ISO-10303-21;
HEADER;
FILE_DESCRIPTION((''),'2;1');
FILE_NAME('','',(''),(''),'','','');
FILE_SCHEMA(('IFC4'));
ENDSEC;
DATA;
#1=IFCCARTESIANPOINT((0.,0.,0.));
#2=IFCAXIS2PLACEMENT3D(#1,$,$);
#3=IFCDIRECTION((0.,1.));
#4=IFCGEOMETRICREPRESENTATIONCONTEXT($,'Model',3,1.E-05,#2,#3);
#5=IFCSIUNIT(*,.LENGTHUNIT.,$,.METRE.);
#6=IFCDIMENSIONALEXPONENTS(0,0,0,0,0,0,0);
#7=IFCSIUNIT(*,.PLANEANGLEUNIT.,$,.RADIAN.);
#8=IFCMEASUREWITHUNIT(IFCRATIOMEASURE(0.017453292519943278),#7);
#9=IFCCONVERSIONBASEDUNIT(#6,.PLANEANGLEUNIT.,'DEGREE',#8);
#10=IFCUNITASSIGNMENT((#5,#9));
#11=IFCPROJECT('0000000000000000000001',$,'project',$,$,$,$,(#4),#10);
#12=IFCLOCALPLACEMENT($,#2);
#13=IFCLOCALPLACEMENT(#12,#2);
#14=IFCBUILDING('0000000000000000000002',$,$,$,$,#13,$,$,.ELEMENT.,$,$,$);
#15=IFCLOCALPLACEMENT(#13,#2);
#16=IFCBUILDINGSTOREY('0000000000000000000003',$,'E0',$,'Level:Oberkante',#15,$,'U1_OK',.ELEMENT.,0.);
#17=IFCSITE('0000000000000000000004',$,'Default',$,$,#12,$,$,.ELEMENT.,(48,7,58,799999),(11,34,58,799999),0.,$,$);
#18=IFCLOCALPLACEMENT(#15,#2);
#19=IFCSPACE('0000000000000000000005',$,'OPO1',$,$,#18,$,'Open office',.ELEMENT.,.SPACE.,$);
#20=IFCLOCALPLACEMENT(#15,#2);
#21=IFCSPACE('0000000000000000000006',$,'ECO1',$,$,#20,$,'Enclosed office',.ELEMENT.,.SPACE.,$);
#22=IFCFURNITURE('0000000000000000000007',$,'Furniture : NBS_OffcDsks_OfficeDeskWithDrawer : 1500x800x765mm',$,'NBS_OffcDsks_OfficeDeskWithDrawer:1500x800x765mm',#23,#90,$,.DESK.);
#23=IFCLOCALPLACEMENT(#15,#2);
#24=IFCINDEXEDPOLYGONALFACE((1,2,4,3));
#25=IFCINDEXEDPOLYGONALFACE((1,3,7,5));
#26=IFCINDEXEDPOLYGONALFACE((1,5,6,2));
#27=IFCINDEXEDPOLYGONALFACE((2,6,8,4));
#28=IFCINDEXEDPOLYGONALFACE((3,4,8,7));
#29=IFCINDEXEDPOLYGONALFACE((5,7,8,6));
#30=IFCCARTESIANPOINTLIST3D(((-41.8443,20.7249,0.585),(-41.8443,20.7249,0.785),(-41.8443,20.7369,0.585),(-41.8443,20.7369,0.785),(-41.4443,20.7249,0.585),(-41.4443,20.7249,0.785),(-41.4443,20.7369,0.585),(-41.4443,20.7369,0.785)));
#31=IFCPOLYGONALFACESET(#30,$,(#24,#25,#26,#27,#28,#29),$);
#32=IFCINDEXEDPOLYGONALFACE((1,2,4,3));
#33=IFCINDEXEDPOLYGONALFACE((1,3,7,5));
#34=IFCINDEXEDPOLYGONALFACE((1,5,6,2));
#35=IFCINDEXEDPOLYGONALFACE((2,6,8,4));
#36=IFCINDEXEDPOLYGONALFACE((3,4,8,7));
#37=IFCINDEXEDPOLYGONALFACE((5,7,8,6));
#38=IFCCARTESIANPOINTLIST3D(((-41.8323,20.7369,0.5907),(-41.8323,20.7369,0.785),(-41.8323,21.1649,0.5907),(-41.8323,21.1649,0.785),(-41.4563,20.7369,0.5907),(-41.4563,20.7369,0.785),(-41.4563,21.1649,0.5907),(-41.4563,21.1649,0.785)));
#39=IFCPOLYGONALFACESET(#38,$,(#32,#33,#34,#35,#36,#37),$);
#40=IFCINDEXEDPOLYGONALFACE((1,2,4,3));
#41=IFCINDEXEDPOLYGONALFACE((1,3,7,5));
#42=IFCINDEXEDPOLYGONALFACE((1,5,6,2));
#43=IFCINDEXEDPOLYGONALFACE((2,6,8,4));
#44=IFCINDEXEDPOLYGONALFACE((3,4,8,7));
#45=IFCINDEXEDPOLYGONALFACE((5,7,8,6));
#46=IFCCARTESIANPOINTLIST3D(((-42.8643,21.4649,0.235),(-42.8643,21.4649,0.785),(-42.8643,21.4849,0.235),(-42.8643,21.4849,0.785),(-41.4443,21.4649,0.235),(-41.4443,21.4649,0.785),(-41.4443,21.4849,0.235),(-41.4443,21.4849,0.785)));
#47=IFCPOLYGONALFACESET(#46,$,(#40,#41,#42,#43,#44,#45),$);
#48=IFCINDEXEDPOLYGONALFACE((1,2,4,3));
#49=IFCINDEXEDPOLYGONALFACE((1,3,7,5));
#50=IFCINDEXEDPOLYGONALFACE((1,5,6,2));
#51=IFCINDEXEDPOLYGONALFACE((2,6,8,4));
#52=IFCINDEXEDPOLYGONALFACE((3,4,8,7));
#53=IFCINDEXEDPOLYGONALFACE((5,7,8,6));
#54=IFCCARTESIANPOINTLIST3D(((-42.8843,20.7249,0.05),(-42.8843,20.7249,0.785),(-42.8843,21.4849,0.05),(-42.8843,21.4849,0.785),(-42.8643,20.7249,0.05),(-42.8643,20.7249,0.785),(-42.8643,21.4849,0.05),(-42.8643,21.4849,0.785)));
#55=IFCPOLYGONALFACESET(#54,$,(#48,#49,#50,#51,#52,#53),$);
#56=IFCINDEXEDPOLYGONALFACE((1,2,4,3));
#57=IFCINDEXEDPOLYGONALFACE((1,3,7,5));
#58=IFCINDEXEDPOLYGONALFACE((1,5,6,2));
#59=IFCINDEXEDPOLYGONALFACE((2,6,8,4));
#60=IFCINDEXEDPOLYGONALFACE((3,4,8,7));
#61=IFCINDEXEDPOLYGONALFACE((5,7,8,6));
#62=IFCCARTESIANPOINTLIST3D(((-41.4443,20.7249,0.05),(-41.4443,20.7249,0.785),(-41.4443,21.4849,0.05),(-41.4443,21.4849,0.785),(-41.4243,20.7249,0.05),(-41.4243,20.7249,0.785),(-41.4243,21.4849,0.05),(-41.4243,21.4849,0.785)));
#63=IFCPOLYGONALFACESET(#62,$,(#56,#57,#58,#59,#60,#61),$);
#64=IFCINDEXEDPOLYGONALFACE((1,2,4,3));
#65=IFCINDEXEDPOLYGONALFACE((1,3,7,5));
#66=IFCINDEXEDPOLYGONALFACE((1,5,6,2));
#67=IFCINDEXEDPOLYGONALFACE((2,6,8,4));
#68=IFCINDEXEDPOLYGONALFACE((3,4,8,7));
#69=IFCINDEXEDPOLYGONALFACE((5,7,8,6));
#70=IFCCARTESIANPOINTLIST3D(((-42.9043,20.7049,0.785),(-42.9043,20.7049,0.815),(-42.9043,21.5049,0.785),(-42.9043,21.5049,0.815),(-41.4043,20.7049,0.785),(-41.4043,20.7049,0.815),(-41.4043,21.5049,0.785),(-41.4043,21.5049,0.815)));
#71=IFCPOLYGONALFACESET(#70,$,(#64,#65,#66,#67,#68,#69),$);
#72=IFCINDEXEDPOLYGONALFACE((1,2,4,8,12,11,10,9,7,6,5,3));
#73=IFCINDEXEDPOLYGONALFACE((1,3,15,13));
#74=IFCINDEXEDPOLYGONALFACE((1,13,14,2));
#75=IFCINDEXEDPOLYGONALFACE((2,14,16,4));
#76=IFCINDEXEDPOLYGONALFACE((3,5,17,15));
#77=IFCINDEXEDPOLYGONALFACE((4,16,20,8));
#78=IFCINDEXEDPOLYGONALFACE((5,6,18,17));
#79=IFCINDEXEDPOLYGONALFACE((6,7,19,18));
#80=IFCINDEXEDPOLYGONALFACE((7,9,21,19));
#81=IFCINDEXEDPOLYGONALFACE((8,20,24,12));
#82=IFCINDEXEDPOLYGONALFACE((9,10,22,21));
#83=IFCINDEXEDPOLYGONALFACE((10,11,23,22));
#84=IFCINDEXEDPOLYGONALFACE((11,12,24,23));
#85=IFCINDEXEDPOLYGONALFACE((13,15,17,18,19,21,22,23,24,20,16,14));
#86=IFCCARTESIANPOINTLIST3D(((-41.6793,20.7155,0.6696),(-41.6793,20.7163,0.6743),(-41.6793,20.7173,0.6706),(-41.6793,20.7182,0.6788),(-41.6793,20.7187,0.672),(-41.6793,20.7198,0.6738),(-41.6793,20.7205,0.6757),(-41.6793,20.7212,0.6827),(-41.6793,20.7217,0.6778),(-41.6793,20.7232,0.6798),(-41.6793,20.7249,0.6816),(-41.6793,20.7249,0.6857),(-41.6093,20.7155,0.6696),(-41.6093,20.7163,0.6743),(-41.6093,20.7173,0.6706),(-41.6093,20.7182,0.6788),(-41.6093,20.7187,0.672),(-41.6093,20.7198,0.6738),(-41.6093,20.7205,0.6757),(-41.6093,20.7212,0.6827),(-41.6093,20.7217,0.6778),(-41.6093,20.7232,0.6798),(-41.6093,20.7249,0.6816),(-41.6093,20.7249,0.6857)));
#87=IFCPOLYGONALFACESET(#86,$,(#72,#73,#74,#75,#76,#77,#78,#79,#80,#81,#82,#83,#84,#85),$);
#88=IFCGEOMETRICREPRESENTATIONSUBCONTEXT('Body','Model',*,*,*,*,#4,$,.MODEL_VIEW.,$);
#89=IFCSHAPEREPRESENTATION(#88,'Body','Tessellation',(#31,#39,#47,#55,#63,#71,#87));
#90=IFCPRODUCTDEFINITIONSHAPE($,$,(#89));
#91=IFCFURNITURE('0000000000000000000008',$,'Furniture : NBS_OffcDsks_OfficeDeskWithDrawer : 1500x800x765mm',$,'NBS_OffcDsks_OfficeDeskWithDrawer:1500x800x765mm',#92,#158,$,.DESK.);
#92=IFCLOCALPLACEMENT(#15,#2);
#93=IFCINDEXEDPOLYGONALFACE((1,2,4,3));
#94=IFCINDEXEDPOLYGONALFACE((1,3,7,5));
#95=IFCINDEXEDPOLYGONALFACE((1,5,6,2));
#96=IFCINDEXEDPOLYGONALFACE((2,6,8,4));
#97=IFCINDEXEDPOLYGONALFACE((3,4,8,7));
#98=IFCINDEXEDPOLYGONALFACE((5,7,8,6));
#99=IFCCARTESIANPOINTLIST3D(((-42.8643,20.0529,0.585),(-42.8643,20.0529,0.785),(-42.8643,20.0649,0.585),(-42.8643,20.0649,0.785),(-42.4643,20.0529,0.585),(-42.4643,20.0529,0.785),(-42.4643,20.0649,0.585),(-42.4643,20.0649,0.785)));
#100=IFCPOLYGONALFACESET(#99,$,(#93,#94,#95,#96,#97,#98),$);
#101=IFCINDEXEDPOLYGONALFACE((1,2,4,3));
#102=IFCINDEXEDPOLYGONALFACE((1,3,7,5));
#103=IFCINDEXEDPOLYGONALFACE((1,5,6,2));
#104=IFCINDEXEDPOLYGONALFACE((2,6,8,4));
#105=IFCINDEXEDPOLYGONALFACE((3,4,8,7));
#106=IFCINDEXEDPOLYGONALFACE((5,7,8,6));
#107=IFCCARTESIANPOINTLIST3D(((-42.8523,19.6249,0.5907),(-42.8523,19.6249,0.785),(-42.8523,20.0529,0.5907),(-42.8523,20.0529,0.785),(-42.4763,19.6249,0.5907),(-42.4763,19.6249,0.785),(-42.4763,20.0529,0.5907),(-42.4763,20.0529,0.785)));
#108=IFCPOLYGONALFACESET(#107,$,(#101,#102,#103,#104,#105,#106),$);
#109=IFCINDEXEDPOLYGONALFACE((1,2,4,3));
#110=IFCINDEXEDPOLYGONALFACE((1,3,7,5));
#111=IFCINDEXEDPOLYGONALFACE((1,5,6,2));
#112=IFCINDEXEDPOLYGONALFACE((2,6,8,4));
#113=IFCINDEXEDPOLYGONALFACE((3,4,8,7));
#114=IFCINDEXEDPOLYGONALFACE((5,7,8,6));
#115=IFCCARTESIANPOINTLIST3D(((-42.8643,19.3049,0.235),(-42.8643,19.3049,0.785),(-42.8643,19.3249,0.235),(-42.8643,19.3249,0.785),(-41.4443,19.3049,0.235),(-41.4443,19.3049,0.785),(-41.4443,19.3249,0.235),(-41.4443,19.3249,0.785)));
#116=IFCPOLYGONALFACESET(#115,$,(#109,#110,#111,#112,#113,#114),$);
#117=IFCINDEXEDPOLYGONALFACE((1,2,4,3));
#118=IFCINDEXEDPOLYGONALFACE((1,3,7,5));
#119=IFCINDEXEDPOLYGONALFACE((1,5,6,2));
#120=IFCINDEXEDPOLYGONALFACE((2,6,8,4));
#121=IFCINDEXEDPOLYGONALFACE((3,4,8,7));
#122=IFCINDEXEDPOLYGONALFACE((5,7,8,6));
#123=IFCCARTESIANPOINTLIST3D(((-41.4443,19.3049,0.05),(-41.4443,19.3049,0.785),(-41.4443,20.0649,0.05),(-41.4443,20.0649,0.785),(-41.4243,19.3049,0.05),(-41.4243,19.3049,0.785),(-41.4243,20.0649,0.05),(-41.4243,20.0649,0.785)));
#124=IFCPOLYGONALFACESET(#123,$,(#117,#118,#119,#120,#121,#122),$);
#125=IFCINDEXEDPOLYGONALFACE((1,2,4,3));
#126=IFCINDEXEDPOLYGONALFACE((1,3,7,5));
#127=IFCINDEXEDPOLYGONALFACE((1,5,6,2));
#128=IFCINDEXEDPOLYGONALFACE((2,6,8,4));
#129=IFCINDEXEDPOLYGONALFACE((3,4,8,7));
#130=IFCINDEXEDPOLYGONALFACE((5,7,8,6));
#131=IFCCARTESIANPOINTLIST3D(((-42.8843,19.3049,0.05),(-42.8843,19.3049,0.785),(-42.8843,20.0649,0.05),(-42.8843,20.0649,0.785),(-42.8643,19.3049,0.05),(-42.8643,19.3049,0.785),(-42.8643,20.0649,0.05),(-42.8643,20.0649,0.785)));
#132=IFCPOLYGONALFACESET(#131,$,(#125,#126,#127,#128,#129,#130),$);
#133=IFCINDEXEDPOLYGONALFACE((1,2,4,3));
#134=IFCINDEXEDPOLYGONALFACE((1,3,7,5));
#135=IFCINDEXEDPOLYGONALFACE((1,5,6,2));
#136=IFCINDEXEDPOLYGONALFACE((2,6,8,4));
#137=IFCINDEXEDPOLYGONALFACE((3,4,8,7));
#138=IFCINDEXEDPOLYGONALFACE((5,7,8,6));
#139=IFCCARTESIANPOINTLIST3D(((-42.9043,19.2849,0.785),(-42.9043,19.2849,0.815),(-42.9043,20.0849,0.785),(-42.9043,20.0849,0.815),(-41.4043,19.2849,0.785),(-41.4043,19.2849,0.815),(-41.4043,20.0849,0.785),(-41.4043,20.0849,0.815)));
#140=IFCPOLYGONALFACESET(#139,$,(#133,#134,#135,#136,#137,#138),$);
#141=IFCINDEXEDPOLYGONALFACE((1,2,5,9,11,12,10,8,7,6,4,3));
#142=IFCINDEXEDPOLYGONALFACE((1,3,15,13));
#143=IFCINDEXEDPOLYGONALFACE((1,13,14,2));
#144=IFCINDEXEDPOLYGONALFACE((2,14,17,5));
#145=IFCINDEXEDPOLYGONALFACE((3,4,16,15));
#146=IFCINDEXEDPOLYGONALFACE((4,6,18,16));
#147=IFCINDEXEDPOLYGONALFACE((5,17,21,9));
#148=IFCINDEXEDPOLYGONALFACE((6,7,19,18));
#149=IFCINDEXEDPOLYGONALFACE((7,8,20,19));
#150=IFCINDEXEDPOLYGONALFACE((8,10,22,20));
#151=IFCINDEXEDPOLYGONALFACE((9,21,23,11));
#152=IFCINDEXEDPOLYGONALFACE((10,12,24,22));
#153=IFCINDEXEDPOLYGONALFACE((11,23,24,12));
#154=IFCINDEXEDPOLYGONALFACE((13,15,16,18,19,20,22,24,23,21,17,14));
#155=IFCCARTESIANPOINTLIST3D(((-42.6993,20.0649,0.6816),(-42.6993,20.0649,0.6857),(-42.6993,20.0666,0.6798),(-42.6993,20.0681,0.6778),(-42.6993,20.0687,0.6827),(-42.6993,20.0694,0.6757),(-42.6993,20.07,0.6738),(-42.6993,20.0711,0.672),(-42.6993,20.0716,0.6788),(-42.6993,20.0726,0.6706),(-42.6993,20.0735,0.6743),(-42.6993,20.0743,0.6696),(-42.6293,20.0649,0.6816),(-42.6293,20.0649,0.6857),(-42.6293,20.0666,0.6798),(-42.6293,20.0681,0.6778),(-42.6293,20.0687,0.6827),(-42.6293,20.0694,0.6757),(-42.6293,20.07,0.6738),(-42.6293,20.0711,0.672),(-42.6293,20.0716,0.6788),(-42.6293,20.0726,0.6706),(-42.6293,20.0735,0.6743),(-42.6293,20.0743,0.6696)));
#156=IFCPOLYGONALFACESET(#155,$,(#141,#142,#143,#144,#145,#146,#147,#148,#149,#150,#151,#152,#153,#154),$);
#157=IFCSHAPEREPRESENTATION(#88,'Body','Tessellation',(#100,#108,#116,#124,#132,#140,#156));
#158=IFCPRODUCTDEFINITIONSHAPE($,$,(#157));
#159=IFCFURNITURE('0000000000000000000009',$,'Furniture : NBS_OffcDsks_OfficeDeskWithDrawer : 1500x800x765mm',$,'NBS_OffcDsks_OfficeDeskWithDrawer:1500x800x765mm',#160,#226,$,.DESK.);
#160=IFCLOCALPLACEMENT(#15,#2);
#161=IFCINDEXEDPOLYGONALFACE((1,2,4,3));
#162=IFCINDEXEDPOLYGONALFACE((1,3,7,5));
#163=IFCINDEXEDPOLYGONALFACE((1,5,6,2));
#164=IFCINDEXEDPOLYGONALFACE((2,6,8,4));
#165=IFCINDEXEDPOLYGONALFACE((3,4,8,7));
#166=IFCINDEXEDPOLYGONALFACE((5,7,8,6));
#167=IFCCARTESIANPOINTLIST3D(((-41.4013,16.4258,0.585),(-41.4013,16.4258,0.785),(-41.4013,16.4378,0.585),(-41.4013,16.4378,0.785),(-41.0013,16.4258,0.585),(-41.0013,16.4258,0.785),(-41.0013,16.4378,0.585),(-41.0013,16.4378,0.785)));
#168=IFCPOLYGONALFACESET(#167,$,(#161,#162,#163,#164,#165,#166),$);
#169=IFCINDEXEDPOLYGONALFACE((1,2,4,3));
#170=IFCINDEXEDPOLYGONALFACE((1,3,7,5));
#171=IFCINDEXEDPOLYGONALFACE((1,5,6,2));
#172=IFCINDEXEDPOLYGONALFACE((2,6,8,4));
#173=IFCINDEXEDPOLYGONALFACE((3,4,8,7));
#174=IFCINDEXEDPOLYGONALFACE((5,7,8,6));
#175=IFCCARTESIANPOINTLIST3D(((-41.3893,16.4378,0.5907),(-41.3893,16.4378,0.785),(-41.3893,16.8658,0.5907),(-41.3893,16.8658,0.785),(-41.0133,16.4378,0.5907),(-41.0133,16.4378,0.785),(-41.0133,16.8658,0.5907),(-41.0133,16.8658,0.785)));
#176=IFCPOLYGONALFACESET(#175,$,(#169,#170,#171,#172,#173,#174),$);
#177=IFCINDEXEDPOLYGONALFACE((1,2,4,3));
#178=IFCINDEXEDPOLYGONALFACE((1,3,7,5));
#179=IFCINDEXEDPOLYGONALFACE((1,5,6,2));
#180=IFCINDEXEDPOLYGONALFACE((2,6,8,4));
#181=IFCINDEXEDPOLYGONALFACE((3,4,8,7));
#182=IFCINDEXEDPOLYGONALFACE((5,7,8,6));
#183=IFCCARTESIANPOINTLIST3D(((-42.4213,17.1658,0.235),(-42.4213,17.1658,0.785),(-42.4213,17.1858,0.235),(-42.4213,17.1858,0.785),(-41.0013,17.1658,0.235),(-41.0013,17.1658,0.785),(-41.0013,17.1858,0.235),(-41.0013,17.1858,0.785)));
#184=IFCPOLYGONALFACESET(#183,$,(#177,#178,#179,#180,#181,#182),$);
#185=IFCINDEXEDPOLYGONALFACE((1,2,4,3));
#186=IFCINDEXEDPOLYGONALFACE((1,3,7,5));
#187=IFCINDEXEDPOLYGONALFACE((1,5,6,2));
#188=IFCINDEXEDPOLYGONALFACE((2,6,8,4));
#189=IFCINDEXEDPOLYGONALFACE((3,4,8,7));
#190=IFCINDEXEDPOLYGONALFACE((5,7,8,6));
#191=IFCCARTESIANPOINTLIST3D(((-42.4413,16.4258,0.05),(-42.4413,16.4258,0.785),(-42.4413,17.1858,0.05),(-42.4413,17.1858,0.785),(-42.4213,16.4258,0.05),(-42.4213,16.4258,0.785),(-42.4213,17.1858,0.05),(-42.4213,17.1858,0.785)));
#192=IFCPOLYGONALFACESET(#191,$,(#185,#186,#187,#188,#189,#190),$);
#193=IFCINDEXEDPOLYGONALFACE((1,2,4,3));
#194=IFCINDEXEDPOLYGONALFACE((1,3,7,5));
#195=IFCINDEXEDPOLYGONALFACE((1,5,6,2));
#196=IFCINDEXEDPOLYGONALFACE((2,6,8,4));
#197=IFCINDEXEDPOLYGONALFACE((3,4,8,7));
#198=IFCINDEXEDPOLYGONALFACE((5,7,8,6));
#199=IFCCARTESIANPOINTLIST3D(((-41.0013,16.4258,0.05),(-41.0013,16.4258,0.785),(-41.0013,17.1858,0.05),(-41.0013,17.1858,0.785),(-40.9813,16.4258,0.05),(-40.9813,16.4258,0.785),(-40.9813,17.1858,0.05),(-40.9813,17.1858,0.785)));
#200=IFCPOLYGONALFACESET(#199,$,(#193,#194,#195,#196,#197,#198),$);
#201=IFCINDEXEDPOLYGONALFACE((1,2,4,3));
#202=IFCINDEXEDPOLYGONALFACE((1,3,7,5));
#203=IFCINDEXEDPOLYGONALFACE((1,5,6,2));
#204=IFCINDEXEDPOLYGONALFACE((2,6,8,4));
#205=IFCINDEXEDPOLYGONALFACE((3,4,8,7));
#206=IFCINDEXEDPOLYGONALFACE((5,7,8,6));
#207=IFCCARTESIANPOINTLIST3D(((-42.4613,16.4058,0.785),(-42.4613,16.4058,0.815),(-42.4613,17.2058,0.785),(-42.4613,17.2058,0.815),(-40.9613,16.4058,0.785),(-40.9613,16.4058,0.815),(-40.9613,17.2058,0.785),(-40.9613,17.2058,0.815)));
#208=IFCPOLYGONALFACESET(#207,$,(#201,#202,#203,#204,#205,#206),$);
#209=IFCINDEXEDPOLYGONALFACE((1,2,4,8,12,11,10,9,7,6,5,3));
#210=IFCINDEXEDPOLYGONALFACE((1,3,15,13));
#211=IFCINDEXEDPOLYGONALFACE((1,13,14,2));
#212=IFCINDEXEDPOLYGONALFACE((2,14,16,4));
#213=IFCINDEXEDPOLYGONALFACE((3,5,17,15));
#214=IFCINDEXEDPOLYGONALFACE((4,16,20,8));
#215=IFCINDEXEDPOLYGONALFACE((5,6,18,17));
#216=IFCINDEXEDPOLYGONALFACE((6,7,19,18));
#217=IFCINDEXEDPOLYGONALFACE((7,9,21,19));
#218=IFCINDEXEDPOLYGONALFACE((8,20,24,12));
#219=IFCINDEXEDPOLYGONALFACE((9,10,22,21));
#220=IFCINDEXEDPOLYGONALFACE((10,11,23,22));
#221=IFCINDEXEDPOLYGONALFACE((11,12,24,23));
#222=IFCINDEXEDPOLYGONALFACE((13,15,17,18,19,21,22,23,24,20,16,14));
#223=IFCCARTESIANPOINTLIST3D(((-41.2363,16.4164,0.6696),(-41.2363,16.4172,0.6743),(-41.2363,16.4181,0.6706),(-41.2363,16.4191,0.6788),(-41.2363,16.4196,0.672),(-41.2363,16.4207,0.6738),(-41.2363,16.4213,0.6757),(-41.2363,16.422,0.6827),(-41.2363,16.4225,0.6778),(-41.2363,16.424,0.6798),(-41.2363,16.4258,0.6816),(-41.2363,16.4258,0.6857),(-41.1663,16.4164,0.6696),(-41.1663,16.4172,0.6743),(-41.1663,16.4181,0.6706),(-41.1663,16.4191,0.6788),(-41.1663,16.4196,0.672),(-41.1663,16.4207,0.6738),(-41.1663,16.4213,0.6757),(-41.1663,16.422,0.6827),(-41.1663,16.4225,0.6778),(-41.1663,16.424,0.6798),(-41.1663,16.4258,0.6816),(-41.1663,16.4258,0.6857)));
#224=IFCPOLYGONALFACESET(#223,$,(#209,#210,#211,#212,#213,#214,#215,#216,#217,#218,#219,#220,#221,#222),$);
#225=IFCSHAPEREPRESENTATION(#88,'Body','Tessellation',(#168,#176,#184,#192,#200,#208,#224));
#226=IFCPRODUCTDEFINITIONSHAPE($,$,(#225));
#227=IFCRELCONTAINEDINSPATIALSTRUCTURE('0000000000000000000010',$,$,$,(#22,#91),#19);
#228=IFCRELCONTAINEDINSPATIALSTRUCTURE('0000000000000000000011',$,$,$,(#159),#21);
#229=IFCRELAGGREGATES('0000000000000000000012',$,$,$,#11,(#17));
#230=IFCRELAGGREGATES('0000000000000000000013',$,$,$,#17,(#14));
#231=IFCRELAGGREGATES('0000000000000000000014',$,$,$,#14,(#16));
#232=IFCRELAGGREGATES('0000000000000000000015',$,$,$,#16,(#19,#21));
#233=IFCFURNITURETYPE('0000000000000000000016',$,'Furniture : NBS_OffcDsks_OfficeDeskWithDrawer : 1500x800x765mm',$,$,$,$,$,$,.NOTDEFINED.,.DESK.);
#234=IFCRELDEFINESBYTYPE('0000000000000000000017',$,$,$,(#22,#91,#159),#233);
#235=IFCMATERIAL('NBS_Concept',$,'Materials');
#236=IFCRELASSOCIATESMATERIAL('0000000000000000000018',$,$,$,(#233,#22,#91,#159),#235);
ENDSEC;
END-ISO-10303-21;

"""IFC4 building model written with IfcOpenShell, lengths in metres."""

from ifc_helpers import new_model, entity, si_unit, converted_unit, direction, frame, origin, place, context, subcontext, project, spatial, line, arc, indexed_curve, outline, extrude, source, transform, mapped, material, type_object, type_shapes, element, save


model = new_model("IFC4")

# Units and contexts
model_context = context("Model", 3, precision=1e-05, world=origin(), true_north=direction((0.0, 1.0)))
body_context = subcontext(model_context, "Body", "Model", "MODEL_VIEW")
ifc_project = project(units=[si_unit("LENGTHUNIT", "METRE"), converted_unit("PLANEANGLEUNIT", "DEGREE", entity("IfcRatioMeasure", 0.017453292519943278), si_unit("PLANEANGLEUNIT", "RADIAN"), dimensions=[0, 0, 0, 0, 0, 0, 0])], contexts=[model_context])

# Site, building, storey
site_placement = place(None, origin())
site = spatial("IfcSite", under=ifc_project, at=site_placement, Name="Default", CompositionType="ELEMENT", RefLatitude=(48, 7, 58, 799999), RefLongitude=(11, 34, 58, 799999), RefElevation=0.0)
building_placement = place(site_placement, origin())
building = spatial("IfcBuilding", under=site, at=building_placement, CompositionType="ELEMENT")
storey_placement = place(building_placement, origin())
storey = spatial("IfcBuildingStorey", under=building, at=storey_placement, Name="E0", ObjectType="Level:Oberkante", LongName="U1_OK", CompositionType="ELEMENT", Elevation=0.0)

# Shared definitions
space_1_placement = place(storey_placement, origin())
space_1 = spatial("IfcSpace", under=storey, at=space_1_placement, Name="OPO1", LongName="Open office", CompositionType="ELEMENT", PredefinedType="SPACE")

# Furniture
ifc_material_1 = material(Name="NBS_Concept", Category="Materials")
furniture_type_1 = type_object("IfcFurnitureType", Name="Furniture : NBS_OffcDsks_OfficeDeskWithDrawer : 1500x800x765mm", AssemblyPlace="NOTDEFINED", PredefinedType="DESK", material=ifc_material_1)
shared_shape_1 = source(origin(), body_context, "Body", "SweptSolid", [
    extrude(outline(indexed_curve([(-0.006, -0.2), (0.006, -0.2), (0.006, 0.2), (-0.006, 0.2), (-0.006, -0.2)], self_intersect=False)), frame((0.51, -0.374, 0.535), z_axis=(0.0, 0.0, 1.0), x_axis=(0.0, 1.0, 0.0)), (0.0, 0.0, 1.0), 0.2),
    extrude(outline(indexed_curve([(-0.188, -0.214), (0.188, -0.214), (0.188, 0.214), (-0.188, 0.214), (-0.188, -0.214)], self_intersect=False)), frame((0.51, -0.154, 0.5407), z_axis=(0.0, 0.0, 1.0), x_axis=(-1.0, 0.0, 0.0)), (0.0, 0.0, 1.0), 0.1943),
    extrude(outline(indexed_curve([(-0.71, -0.01), (0.71, -0.01), (0.71, 0.01), (-0.71, 0.01), (-0.71, -0.01)], self_intersect=False)), frame((0.0, 0.37, 0.185), z_axis=(0.0, 0.0, 1.0), x_axis=(-1.0, 0.0, 0.0)), (0.0, 0.0, 1.0), 0.55),
    extrude(outline(indexed_curve([(-0.01, -0.38), (0.01, -0.38), (0.01, 0.38), (-0.01, 0.38), (-0.01, -0.38)], self_intersect=False)), frame((-0.72, 0.0, 0.0), z_axis=(0.0, 0.0, 1.0), x_axis=(-1.0, 0.0, 0.0)), (0.0, 0.0, 1.0), 0.735),
    extrude(outline(indexed_curve([(-0.01, -0.38), (0.01, -0.38), (0.01, 0.38), (-0.01, 0.38), (-0.01, -0.38)], self_intersect=False)), frame((0.72, 0.0, 0.0), z_axis=(0.0, 0.0, 1.0), x_axis=(-1.0, 0.0, 0.0)), (0.0, 0.0, 1.0), 0.735),
    extrude(outline(indexed_curve([(-0.75, -0.4), (0.75, -0.4), (0.75, 0.4), (-0.75, 0.4), (-0.75, -0.4)], self_intersect=False)), frame((0.0, 0.0, 0.735), z_axis=(0.0, 0.0, 1.0), x_axis=(-1.0, 0.0, 0.0)), (0.0, 0.0, 1.0), 0.03),
    extrude(outline(indexed_curve([(0.0086, -0.0059), (0.0061, -0.0027), (0.0025, -0.001), (-0.0007, 0.0009), (-0.0034, 0.0035), (-0.0076, 0.0035), (-0.0007, -0.0032)], segments=[arc(1, 2, 3), arc(3, 4, 5), line(5, 6), arc(6, 7, 1)], self_intersect=False)), frame((0.475, -0.3835, 0.6281), z_axis=(1.0, 0.0, 0.0), x_axis=(0.0, 0.0, -1.0)), (0.0, 0.0, 1.0), 0.07),
])
type_shapes(furniture_type_1, [shared_shape_1])
furniture_1_placement = place(space_1_placement, frame((-42.1543, 21.1049, 0.05)))
element("IfcFurniture", 1, at=furniture_1_placement, inside=space_1, type_object=furniture_type_1, material=ifc_material_1, Name="Furniture : NBS_OffcDsks_OfficeDeskWithDrawer : 1500x800x765mm", ObjectType="NBS_OffcDsks_OfficeDeskWithDrawer:1500x800x765mm", PredefinedType="DESK", context=body_context, shape_type="MappedRepresentation", body=[
    mapped(shared_shape_1, transform((0.0, 0.0, 0.0), scale=1.0)),
])
furniture_2_placement = place(space_1_placement, frame((-42.1543, 19.6849, 0.05), z_axis=(0.0, 0.0, 1.0), x_axis=(-1.0, 0.0, 0.0)))
element("IfcFurniture", 2, at=furniture_2_placement, inside=space_1, type_object=furniture_type_1, material=ifc_material_1, Name="Furniture : NBS_OffcDsks_OfficeDeskWithDrawer : 1500x800x765mm", ObjectType="NBS_OffcDsks_OfficeDeskWithDrawer:1500x800x765mm", PredefinedType="DESK", context=body_context, shape_type="MappedRepresentation", body=[
    mapped(shared_shape_1, transform((0.0, 0.0, 0.0), scale=1.0)),
])

# Shared definitions
space_2_placement = place(storey_placement, origin())
space_2 = spatial("IfcSpace", under=storey, at=space_2_placement, Name="ECO1", LongName="Enclosed office", CompositionType="ELEMENT", PredefinedType="SPACE")

# Furniture
furniture_3_placement = place(space_2_placement, frame((-41.7113, 16.8058, 0.05)))
element("IfcFurniture", 3, at=furniture_3_placement, inside=space_2, type_object=furniture_type_1, material=ifc_material_1, Name="Furniture : NBS_OffcDsks_OfficeDeskWithDrawer : 1500x800x765mm", ObjectType="NBS_OffcDsks_OfficeDeskWithDrawer:1500x800x765mm", PredefinedType="DESK", context=body_context, shape_type="MappedRepresentation", body=[
    mapped(shared_shape_1, transform((0.0, 0.0, 0.0), scale=1.0)),
])

save(model, "model.ifc")
